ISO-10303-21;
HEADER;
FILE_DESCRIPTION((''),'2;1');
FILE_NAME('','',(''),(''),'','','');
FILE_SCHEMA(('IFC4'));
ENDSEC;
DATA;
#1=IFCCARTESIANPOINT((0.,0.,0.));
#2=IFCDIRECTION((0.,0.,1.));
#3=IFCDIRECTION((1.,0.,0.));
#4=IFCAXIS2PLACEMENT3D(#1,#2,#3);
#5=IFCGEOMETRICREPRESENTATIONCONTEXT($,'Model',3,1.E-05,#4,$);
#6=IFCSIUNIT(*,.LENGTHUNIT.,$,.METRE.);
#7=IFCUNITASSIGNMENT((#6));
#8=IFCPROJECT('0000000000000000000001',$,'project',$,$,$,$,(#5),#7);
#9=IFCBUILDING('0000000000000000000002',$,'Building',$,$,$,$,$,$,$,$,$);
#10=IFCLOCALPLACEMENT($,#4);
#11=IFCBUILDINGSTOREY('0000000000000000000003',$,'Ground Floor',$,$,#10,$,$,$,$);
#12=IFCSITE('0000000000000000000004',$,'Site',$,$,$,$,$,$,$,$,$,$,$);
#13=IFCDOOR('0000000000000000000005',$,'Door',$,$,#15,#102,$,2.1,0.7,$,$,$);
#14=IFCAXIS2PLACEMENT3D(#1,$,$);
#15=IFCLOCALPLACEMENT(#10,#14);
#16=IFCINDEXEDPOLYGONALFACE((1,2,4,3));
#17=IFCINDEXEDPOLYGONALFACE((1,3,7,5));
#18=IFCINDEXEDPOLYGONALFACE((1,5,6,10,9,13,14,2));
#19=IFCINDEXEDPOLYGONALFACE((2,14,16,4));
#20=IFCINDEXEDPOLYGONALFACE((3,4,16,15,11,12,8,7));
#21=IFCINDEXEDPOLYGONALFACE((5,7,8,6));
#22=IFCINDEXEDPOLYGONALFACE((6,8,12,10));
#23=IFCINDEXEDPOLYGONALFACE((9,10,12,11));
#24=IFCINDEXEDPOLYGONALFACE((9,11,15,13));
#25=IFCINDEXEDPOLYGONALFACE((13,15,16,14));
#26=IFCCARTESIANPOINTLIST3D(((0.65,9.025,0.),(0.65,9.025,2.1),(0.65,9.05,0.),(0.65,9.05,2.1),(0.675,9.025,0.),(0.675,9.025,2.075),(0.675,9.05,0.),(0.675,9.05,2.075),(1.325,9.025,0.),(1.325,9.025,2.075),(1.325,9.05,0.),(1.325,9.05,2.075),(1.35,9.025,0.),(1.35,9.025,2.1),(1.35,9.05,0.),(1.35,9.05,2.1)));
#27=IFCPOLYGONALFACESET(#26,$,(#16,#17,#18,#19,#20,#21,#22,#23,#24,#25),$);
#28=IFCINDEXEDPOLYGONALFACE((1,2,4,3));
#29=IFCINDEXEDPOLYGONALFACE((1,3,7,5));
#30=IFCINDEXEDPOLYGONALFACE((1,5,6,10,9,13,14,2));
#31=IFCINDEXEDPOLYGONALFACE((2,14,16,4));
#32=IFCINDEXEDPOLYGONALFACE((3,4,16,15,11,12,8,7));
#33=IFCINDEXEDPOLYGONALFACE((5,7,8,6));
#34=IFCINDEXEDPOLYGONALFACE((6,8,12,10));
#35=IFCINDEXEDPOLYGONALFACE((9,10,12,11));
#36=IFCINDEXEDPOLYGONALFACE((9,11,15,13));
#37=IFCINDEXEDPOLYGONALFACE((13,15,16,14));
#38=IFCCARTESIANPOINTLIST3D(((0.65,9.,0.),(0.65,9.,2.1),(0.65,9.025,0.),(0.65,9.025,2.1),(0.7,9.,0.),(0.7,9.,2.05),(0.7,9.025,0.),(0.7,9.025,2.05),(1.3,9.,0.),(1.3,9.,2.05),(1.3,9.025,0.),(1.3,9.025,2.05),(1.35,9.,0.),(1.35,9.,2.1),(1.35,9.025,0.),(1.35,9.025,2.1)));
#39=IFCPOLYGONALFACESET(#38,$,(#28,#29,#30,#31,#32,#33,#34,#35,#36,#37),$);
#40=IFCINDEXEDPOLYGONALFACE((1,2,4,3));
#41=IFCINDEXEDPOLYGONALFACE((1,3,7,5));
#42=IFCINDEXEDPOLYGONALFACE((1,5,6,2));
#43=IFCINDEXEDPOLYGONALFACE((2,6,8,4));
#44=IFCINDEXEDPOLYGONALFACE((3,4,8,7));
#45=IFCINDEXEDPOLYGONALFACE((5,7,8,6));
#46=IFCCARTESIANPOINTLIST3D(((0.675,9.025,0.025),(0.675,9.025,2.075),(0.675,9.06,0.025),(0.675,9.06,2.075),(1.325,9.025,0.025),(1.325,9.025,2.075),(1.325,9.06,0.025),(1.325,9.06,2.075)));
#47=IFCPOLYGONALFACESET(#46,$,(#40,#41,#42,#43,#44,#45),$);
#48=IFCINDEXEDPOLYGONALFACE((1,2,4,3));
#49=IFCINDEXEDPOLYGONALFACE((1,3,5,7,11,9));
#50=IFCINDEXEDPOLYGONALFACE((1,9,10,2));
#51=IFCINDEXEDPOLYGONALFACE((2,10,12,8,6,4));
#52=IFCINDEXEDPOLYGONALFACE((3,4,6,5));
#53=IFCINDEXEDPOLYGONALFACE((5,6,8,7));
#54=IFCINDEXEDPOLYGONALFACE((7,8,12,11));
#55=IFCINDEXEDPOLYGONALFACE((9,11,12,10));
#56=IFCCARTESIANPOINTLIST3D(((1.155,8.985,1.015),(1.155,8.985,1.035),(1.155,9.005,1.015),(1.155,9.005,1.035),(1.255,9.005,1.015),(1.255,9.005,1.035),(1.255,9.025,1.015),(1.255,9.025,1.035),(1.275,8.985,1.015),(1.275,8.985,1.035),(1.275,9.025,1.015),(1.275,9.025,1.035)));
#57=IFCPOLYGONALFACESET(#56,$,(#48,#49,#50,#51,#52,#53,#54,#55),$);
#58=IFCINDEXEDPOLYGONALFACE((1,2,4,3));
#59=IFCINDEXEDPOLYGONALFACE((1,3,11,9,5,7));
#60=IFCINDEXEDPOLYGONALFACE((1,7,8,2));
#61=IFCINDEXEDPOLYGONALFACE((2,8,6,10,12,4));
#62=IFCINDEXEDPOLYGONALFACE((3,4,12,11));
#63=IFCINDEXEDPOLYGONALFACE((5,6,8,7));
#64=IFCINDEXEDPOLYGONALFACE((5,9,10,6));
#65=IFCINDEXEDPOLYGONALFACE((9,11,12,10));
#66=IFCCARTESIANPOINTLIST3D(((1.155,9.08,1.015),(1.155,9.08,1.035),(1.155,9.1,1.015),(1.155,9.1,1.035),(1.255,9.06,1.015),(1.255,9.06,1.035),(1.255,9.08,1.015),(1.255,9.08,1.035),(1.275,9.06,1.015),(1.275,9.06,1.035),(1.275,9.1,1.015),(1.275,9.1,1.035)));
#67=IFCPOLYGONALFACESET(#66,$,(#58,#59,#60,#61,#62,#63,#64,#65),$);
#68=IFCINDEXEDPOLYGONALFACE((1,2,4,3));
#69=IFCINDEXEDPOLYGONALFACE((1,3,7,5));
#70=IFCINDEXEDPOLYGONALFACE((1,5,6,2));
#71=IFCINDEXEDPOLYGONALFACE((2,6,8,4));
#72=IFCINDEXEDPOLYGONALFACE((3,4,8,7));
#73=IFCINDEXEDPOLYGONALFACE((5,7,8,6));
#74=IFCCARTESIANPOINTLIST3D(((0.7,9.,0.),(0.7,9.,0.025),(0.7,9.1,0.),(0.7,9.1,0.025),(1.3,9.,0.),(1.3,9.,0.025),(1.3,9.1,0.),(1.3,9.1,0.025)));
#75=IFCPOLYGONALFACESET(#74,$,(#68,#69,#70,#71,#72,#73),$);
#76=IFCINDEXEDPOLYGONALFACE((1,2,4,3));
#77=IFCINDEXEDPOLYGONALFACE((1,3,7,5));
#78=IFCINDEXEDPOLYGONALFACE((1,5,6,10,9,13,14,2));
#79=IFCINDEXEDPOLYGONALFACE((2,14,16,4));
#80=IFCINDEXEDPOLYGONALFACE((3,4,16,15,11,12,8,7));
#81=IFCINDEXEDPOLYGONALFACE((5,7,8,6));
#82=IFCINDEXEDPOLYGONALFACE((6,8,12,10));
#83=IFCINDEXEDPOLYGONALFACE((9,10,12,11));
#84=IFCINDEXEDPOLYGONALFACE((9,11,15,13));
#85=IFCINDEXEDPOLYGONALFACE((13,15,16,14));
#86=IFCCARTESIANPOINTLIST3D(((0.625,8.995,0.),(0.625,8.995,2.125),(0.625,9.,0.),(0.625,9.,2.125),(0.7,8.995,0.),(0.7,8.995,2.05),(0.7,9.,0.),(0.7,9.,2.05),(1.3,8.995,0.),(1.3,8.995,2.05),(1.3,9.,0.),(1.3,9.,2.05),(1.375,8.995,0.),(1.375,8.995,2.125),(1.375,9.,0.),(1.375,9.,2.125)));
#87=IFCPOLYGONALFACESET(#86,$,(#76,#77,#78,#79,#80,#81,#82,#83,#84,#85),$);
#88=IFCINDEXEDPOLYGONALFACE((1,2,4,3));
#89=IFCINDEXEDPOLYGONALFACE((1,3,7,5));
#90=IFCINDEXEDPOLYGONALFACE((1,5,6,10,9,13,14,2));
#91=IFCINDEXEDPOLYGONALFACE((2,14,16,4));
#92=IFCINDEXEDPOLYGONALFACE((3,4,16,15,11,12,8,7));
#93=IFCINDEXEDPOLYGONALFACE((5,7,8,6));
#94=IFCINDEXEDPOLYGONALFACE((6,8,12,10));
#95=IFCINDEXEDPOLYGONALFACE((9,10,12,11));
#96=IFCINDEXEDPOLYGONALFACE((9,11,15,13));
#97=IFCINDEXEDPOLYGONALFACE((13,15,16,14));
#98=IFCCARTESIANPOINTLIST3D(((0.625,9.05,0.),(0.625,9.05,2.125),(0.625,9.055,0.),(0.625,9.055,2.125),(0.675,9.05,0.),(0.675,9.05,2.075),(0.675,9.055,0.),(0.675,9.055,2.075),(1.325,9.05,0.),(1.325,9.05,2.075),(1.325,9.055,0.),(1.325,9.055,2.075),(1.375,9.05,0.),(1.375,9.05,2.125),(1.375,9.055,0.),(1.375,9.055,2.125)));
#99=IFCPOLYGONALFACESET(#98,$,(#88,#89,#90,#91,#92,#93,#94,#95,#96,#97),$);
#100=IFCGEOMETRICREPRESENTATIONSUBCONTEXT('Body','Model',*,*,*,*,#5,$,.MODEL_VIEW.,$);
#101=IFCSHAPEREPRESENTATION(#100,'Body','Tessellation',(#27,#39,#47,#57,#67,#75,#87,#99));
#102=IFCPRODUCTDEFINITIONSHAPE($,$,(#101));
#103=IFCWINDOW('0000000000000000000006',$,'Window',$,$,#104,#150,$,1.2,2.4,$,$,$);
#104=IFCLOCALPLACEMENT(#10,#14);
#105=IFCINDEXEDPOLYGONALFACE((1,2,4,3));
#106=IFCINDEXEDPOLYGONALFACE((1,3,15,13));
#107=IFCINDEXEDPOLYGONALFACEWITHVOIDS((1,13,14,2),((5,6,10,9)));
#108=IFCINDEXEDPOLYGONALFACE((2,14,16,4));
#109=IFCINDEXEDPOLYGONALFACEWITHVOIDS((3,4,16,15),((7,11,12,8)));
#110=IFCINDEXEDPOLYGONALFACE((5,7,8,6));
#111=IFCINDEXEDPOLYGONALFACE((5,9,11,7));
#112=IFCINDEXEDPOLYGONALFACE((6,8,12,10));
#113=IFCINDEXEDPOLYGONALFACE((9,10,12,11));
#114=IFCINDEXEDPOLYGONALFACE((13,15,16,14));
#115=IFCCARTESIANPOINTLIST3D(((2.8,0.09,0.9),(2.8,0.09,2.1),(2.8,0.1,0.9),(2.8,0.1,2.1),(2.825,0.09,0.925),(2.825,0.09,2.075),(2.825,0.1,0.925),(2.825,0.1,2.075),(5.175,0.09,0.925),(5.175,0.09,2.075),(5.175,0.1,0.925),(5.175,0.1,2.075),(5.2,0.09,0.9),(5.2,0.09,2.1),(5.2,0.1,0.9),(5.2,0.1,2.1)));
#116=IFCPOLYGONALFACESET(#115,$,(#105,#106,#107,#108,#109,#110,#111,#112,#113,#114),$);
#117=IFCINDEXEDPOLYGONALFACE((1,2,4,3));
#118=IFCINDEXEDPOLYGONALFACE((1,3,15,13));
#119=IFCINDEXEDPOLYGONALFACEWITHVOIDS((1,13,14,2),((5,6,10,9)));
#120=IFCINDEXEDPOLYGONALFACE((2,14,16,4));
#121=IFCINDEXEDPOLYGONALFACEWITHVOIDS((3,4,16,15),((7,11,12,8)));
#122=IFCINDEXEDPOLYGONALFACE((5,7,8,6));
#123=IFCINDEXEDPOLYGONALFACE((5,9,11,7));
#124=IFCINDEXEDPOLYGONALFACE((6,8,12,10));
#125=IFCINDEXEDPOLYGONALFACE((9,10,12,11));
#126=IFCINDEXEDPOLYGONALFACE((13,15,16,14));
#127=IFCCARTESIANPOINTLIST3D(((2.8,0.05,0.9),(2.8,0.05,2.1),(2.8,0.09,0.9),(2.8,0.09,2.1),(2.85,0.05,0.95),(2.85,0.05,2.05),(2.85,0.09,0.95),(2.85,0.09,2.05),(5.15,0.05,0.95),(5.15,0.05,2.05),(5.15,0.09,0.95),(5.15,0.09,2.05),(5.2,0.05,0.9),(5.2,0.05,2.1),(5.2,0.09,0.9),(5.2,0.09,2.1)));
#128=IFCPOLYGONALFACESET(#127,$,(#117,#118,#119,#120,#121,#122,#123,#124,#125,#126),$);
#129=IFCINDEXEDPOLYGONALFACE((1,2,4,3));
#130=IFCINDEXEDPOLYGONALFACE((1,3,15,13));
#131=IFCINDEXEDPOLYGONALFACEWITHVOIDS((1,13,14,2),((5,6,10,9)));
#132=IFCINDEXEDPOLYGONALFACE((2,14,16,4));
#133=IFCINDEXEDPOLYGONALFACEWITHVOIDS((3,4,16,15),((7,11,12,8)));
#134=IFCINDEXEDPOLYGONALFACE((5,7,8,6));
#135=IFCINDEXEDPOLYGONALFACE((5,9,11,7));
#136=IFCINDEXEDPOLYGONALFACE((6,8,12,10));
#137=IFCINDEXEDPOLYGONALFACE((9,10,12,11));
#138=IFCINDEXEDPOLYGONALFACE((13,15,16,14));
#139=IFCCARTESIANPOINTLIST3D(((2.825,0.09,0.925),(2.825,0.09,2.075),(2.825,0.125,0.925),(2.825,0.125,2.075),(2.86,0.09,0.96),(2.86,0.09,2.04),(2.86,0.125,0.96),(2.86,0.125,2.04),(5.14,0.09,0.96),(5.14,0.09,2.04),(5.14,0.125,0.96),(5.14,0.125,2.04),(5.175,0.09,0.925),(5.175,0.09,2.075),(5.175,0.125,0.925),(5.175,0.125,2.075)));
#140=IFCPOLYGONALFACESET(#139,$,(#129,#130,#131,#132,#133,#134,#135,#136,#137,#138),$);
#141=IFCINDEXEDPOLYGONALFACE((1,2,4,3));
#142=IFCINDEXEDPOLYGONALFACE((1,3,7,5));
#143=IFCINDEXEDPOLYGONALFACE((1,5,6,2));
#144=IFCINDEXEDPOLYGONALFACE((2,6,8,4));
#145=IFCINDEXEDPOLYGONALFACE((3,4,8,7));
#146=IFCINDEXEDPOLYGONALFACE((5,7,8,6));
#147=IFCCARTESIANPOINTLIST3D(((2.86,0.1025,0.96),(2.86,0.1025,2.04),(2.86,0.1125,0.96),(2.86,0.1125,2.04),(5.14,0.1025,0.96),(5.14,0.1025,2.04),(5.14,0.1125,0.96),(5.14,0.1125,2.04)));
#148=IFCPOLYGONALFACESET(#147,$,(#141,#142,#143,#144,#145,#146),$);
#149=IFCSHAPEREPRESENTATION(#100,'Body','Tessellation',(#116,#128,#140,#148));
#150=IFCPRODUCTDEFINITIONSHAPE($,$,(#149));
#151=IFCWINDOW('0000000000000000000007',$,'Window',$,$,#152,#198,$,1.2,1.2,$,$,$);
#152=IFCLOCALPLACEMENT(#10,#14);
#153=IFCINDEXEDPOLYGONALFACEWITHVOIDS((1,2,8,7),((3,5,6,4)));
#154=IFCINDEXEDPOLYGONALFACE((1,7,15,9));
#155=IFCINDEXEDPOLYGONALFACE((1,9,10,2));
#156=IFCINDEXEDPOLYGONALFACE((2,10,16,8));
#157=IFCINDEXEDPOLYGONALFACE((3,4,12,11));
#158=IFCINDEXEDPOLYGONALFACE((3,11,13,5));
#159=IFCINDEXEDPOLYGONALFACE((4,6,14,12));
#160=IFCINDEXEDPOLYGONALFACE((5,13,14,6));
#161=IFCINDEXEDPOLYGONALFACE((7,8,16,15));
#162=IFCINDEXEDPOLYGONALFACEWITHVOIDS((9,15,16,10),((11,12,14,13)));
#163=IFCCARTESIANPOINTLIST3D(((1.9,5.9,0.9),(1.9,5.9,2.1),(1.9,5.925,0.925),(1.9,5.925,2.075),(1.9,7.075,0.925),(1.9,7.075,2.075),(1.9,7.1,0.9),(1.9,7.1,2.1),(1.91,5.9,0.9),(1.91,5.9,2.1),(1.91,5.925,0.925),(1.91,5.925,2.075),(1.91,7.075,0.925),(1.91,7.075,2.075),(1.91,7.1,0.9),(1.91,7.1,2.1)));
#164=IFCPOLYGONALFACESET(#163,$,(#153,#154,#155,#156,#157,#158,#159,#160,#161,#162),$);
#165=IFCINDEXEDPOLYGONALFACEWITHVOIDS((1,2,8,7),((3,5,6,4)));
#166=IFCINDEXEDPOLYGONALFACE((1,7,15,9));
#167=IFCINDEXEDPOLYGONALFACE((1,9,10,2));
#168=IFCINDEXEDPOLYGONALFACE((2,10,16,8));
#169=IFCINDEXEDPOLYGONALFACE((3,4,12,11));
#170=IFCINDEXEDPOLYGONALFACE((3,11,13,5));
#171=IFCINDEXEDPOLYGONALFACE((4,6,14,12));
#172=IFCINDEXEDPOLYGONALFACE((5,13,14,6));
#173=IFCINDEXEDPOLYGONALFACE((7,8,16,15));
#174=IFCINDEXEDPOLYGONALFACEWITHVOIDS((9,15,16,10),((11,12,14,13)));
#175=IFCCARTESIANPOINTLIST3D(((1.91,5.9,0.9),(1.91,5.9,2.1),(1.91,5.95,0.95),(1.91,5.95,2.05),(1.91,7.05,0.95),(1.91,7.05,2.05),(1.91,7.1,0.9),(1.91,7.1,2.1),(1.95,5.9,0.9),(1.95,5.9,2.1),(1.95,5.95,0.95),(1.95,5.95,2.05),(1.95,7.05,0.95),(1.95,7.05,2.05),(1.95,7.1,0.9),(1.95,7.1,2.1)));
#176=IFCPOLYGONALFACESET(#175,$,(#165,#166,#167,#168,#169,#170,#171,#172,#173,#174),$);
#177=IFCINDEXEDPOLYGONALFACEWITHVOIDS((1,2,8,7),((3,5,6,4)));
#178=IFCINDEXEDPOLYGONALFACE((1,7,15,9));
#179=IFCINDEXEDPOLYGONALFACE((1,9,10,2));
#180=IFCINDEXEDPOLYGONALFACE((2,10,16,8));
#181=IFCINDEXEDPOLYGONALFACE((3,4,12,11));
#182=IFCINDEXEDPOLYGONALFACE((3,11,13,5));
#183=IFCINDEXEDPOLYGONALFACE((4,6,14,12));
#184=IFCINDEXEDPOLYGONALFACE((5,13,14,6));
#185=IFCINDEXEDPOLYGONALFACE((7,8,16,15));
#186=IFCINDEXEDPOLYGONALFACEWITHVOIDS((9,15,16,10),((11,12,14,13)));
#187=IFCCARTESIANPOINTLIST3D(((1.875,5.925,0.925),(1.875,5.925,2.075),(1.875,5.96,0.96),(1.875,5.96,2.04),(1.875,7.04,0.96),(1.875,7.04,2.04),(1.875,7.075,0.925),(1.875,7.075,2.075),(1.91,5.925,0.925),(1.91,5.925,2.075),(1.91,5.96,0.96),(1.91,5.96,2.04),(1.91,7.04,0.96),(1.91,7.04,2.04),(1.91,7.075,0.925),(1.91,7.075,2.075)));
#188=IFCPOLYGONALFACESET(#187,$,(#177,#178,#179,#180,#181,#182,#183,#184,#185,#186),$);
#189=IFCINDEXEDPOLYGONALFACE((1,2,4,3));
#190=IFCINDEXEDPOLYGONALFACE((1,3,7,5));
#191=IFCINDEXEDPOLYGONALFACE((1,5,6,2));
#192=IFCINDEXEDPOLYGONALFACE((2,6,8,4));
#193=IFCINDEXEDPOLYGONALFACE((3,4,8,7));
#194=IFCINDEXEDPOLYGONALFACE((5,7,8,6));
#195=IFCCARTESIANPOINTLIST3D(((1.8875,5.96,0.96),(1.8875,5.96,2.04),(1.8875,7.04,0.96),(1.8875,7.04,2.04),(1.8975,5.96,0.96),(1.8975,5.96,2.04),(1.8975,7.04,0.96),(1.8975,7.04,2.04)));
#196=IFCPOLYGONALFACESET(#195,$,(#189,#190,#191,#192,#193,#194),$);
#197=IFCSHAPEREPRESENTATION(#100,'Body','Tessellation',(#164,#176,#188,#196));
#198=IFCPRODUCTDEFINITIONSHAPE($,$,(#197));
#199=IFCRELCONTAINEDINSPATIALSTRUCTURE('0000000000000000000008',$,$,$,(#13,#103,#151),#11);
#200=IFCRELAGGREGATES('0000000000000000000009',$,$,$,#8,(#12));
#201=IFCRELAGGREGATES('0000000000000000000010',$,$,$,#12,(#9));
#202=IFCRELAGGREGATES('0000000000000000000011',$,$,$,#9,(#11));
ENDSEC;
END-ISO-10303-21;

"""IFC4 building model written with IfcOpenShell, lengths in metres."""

from ifc_helpers import new_model, si_unit, frame, origin_with_axes, place, context, subcontext, project, spatial, line, indexed_curve, outline, extrude, element, save


model = new_model("IFC4")

# Units and contexts
model_context = context("Model", 3, precision=1e-05, world=origin_with_axes())
body_context = subcontext(model_context, "Body", "Model", "MODEL_VIEW")
ifc_project = project(units=[si_unit("LENGTHUNIT", "METRE")], contexts=[model_context])

# Site, building, storey
site = spatial("IfcSite", under=ifc_project, Name="Site")
building = spatial("IfcBuilding", under=site, Name="Building")
storey_placement = place(None, origin_with_axes())
storey = spatial("IfcBuildingStorey", under=building, at=storey_placement, Name="Ground Floor")

# Door
door_1_placement = place(storey_placement, frame((0.65, 9.0, 0.0), z_axis=(0.0, 0.0, 1.0), x_axis=(1.0, 0.0, 0.0)))
element("IfcDoor", 1, at=door_1_placement, inside=storey, Name="Door", OverallHeight=2.1, OverallWidth=0.7, context=body_context, shape_type="SweptSolid", body=[
    extrude(outline(indexed_curve([(0.0, 0.0), (0.0, 2.1), (0.7, 2.1), (0.7, 0.0), (0.675, 0.0), (0.675, 2.075), (0.025, 2.075), (0.025, 0.0)], segments=[line(1, 2, 3, 4, 5, 6, 7, 8, 1)])), frame((0.0, 0.025, 0.0), z_axis=(0.0, -1.0, 0.0), x_axis=(1.0, 0.0, 0.0)), (0.0, 0.0, -1.0), 0.025),
    extrude(outline(indexed_curve([(0.0, 0.0), (0.0, 2.1), (0.7, 2.1), (0.7, 0.0), (0.65, 0.0), (0.65, 2.05), (0.05, 2.05), (0.05, 0.0)], segments=[line(1, 2, 3, 4, 5, 6, 7, 8, 1)])), frame((0.0, 0.0, 0.0), z_axis=(0.0, -1.0, 0.0), x_axis=(1.0, 0.0, 0.0)), (0.0, 0.0, -1.0), 0.025),
    extrude(outline(indexed_curve([(0.0, 0.0), (0.65, 0.0), (0.65, 0.035), (0.0, 0.035)], segments=[line(1, 2, 3, 4, 1)])), frame((0.025, 0.025, 0.025), z_axis=(0.0, 0.0, 1.0), x_axis=(1.0, 0.0, 0.0)), (0.0, 0.0, 1.0), 2.05),
    extrude(outline(indexed_curve([(0.0, 0.0), (0.0, -0.04), (-0.12, -0.04), (-0.12, -0.02), (-0.02, -0.02), (-0.02, 0.0)], segments=[line(1, 2, 3, 4, 5, 6, 1)])), frame((0.625, 0.025, 1.015), z_axis=(0.0, 0.0, 1.0), x_axis=(1.0, 0.0, 0.0)), (0.0, 0.0, 1.0), 0.02),
    extrude(outline(indexed_curve([(0.0, 0.0), (0.0, 0.04), (-0.12, 0.04), (-0.12, 0.02), (-0.02, 0.02), (-0.02, 0.0)], segments=[line(1, 2, 3, 4, 5, 6, 1)])), frame((0.625, 0.06, 1.015), z_axis=(0.0, 0.0, 1.0), x_axis=(1.0, 0.0, 0.0)), (0.0, 0.0, 1.0), 0.02),
    extrude(outline(indexed_curve([(0.0, 0.0), (0.6, 0.0), (0.6, 0.1), (0.0, 0.1)], segments=[line(1, 2, 3, 4, 1)])), frame((0.05, 0.0, 0.0), z_axis=(0.0, 0.0, 1.0), x_axis=(1.0, 0.0, 0.0)), (0.0, 0.0, 1.0), 0.025),
    extrude(outline(indexed_curve([(0.0, 0.0), (0.0, 2.125), (0.75, 2.125), (0.75, 0.0), (0.675, 0.0), (0.675, 2.05), (0.075, 2.05), (0.075, 0.0)], segments=[line(1, 2, 3, 4, 5, 6, 7, 8, 1)])), frame((-0.025, -0.005, 0.0), z_axis=(0.0, -1.0, 0.0), x_axis=(1.0, 0.0, 0.0)), (0.0, 0.0, -1.0), 0.005),
    extrude(outline(indexed_curve([(0.0, 0.0), (0.0, 2.125), (0.75, 2.125), (0.75, 0.0), (0.7, 0.0), (0.7, 2.075), (0.05, 2.075), (0.05, 0.0)], segments=[line(1, 2, 3, 4, 5, 6, 7, 8, 1)])), frame((-0.025, 0.05, 0.0), z_axis=(0.0, -1.0, 0.0), x_axis=(1.0, 0.0, 0.0)), (0.0, 0.0, -1.0), 0.005),
])

# Windows
window_1_placement = place(storey_placement, frame((2.8, 0.0, 0.9), z_axis=(0.0, 0.0, 1.0), x_axis=(1.0, 0.0, 0.0)))
element("IfcWindow", 2, at=window_1_placement, inside=storey, Name="Window", OverallHeight=1.2, OverallWidth=2.4, context=body_context, shape_type="SweptSolid", body=[
    extrude(outline(indexed_curve([(0.0, 0.0), (2.4, 0.0), (2.4, 1.2), (0.0, 1.2)], segments=[line(1, 2, 3, 4, 1)]), holes=[indexed_curve([(0.025, 0.025), (2.375, 0.025), (2.375, 1.175), (0.025, 1.175)], segments=[line(1, 2, 3, 4, 1)])]), frame((0.0, 0.09, 0.0), z_axis=(0.0, -1.0, 0.0), x_axis=(1.0, 0.0, 0.0)), (0.0, 0.0, -1.0), 0.01),
    extrude(outline(indexed_curve([(0.0, 0.0), (2.4, 0.0), (2.4, 1.2), (0.0, 1.2)], segments=[line(1, 2, 3, 4, 1)]), holes=[indexed_curve([(0.05, 0.05), (2.35, 0.05), (2.35, 1.15), (0.05, 1.15)], segments=[line(1, 2, 3, 4, 1)])]), frame((0.0, 0.05, 0.0), z_axis=(0.0, -1.0, 0.0), x_axis=(1.0, 0.0, 0.0)), (0.0, 0.0, -1.0), 0.04),
    extrude(outline(indexed_curve([(0.0, 0.0), (2.35, 0.0), (2.35, 1.15), (0.0, 1.15)], segments=[line(1, 2, 3, 4, 1)]), holes=[indexed_curve([(0.035, 0.035), (2.315, 0.035), (2.315, 1.115), (0.035, 1.115)], segments=[line(1, 2, 3, 4, 1)])]), frame((0.025, 0.09, 0.025), z_axis=(0.0, -1.0, 0.0), x_axis=(1.0, 0.0, 0.0)), (0.0, 0.0, -1.0), 0.035),
    extrude(outline(indexed_curve([(0.035, 0.035), (2.315, 0.035), (2.315, 1.115), (0.035, 1.115)], segments=[line(1, 2, 3, 4, 1)])), frame((0.025, 0.1025, 0.025), z_axis=(0.0, -1.0, 0.0), x_axis=(1.0, 0.0, 0.0)), (0.0, 0.0, -1.0), 0.01),
])
window_2_placement = place(storey_placement, frame((2.0, 5.9, 0.9), z_axis=(0.0, 0.0, 1.0), x_axis=(0.0, 1.0, 0.0)))
element("IfcWindow", 3, at=window_2_placement, inside=storey, Name="Window", OverallHeight=1.2, OverallWidth=1.2, context=body_context, shape_type="SweptSolid", body=[
    extrude(outline(indexed_curve([(0.0, 0.0), (1.2, 0.0), (1.2, 1.2), (0.0, 1.2)], segments=[line(1, 2, 3, 4, 1)]), holes=[indexed_curve([(0.025, 0.025), (1.175, 0.025), (1.175, 1.175), (0.025, 1.175)], segments=[line(1, 2, 3, 4, 1)])]), frame((0.0, 0.09, 0.0), z_axis=(0.0, -1.0, 0.0), x_axis=(1.0, 0.0, 0.0)), (0.0, 0.0, -1.0), 0.01),
    extrude(outline(indexed_curve([(0.0, 0.0), (1.2, 0.0), (1.2, 1.2), (0.0, 1.2)], segments=[line(1, 2, 3, 4, 1)]), holes=[indexed_curve([(0.05, 0.05), (1.15, 0.05), (1.15, 1.15), (0.05, 1.15)], segments=[line(1, 2, 3, 4, 1)])]), frame((0.0, 0.05, 0.0), z_axis=(0.0, -1.0, 0.0), x_axis=(1.0, 0.0, 0.0)), (0.0, 0.0, -1.0), 0.04),
    extrude(outline(indexed_curve([(0.0, 0.0), (1.15, 0.0), (1.15, 1.15), (0.0, 1.15)], segments=[line(1, 2, 3, 4, 1)]), holes=[indexed_curve([(0.035, 0.035), (1.115, 0.035), (1.115, 1.115), (0.035, 1.115)], segments=[line(1, 2, 3, 4, 1)])]), frame((0.025, 0.09, 0.025), z_axis=(0.0, -1.0, 0.0), x_axis=(1.0, 0.0, 0.0)), (0.0, 0.0, -1.0), 0.035),
    extrude(outline(indexed_curve([(0.035, 0.035), (1.115, 0.035), (1.115, 1.115), (0.035, 1.115)], segments=[line(1, 2, 3, 4, 1)])), frame((0.025, 0.1025, 0.025), z_axis=(0.0, -1.0, 0.0), x_axis=(1.0, 0.0, 0.0)), (0.0, 0.0, -1.0), 0.01),
])

save(model, "model.ifc")
